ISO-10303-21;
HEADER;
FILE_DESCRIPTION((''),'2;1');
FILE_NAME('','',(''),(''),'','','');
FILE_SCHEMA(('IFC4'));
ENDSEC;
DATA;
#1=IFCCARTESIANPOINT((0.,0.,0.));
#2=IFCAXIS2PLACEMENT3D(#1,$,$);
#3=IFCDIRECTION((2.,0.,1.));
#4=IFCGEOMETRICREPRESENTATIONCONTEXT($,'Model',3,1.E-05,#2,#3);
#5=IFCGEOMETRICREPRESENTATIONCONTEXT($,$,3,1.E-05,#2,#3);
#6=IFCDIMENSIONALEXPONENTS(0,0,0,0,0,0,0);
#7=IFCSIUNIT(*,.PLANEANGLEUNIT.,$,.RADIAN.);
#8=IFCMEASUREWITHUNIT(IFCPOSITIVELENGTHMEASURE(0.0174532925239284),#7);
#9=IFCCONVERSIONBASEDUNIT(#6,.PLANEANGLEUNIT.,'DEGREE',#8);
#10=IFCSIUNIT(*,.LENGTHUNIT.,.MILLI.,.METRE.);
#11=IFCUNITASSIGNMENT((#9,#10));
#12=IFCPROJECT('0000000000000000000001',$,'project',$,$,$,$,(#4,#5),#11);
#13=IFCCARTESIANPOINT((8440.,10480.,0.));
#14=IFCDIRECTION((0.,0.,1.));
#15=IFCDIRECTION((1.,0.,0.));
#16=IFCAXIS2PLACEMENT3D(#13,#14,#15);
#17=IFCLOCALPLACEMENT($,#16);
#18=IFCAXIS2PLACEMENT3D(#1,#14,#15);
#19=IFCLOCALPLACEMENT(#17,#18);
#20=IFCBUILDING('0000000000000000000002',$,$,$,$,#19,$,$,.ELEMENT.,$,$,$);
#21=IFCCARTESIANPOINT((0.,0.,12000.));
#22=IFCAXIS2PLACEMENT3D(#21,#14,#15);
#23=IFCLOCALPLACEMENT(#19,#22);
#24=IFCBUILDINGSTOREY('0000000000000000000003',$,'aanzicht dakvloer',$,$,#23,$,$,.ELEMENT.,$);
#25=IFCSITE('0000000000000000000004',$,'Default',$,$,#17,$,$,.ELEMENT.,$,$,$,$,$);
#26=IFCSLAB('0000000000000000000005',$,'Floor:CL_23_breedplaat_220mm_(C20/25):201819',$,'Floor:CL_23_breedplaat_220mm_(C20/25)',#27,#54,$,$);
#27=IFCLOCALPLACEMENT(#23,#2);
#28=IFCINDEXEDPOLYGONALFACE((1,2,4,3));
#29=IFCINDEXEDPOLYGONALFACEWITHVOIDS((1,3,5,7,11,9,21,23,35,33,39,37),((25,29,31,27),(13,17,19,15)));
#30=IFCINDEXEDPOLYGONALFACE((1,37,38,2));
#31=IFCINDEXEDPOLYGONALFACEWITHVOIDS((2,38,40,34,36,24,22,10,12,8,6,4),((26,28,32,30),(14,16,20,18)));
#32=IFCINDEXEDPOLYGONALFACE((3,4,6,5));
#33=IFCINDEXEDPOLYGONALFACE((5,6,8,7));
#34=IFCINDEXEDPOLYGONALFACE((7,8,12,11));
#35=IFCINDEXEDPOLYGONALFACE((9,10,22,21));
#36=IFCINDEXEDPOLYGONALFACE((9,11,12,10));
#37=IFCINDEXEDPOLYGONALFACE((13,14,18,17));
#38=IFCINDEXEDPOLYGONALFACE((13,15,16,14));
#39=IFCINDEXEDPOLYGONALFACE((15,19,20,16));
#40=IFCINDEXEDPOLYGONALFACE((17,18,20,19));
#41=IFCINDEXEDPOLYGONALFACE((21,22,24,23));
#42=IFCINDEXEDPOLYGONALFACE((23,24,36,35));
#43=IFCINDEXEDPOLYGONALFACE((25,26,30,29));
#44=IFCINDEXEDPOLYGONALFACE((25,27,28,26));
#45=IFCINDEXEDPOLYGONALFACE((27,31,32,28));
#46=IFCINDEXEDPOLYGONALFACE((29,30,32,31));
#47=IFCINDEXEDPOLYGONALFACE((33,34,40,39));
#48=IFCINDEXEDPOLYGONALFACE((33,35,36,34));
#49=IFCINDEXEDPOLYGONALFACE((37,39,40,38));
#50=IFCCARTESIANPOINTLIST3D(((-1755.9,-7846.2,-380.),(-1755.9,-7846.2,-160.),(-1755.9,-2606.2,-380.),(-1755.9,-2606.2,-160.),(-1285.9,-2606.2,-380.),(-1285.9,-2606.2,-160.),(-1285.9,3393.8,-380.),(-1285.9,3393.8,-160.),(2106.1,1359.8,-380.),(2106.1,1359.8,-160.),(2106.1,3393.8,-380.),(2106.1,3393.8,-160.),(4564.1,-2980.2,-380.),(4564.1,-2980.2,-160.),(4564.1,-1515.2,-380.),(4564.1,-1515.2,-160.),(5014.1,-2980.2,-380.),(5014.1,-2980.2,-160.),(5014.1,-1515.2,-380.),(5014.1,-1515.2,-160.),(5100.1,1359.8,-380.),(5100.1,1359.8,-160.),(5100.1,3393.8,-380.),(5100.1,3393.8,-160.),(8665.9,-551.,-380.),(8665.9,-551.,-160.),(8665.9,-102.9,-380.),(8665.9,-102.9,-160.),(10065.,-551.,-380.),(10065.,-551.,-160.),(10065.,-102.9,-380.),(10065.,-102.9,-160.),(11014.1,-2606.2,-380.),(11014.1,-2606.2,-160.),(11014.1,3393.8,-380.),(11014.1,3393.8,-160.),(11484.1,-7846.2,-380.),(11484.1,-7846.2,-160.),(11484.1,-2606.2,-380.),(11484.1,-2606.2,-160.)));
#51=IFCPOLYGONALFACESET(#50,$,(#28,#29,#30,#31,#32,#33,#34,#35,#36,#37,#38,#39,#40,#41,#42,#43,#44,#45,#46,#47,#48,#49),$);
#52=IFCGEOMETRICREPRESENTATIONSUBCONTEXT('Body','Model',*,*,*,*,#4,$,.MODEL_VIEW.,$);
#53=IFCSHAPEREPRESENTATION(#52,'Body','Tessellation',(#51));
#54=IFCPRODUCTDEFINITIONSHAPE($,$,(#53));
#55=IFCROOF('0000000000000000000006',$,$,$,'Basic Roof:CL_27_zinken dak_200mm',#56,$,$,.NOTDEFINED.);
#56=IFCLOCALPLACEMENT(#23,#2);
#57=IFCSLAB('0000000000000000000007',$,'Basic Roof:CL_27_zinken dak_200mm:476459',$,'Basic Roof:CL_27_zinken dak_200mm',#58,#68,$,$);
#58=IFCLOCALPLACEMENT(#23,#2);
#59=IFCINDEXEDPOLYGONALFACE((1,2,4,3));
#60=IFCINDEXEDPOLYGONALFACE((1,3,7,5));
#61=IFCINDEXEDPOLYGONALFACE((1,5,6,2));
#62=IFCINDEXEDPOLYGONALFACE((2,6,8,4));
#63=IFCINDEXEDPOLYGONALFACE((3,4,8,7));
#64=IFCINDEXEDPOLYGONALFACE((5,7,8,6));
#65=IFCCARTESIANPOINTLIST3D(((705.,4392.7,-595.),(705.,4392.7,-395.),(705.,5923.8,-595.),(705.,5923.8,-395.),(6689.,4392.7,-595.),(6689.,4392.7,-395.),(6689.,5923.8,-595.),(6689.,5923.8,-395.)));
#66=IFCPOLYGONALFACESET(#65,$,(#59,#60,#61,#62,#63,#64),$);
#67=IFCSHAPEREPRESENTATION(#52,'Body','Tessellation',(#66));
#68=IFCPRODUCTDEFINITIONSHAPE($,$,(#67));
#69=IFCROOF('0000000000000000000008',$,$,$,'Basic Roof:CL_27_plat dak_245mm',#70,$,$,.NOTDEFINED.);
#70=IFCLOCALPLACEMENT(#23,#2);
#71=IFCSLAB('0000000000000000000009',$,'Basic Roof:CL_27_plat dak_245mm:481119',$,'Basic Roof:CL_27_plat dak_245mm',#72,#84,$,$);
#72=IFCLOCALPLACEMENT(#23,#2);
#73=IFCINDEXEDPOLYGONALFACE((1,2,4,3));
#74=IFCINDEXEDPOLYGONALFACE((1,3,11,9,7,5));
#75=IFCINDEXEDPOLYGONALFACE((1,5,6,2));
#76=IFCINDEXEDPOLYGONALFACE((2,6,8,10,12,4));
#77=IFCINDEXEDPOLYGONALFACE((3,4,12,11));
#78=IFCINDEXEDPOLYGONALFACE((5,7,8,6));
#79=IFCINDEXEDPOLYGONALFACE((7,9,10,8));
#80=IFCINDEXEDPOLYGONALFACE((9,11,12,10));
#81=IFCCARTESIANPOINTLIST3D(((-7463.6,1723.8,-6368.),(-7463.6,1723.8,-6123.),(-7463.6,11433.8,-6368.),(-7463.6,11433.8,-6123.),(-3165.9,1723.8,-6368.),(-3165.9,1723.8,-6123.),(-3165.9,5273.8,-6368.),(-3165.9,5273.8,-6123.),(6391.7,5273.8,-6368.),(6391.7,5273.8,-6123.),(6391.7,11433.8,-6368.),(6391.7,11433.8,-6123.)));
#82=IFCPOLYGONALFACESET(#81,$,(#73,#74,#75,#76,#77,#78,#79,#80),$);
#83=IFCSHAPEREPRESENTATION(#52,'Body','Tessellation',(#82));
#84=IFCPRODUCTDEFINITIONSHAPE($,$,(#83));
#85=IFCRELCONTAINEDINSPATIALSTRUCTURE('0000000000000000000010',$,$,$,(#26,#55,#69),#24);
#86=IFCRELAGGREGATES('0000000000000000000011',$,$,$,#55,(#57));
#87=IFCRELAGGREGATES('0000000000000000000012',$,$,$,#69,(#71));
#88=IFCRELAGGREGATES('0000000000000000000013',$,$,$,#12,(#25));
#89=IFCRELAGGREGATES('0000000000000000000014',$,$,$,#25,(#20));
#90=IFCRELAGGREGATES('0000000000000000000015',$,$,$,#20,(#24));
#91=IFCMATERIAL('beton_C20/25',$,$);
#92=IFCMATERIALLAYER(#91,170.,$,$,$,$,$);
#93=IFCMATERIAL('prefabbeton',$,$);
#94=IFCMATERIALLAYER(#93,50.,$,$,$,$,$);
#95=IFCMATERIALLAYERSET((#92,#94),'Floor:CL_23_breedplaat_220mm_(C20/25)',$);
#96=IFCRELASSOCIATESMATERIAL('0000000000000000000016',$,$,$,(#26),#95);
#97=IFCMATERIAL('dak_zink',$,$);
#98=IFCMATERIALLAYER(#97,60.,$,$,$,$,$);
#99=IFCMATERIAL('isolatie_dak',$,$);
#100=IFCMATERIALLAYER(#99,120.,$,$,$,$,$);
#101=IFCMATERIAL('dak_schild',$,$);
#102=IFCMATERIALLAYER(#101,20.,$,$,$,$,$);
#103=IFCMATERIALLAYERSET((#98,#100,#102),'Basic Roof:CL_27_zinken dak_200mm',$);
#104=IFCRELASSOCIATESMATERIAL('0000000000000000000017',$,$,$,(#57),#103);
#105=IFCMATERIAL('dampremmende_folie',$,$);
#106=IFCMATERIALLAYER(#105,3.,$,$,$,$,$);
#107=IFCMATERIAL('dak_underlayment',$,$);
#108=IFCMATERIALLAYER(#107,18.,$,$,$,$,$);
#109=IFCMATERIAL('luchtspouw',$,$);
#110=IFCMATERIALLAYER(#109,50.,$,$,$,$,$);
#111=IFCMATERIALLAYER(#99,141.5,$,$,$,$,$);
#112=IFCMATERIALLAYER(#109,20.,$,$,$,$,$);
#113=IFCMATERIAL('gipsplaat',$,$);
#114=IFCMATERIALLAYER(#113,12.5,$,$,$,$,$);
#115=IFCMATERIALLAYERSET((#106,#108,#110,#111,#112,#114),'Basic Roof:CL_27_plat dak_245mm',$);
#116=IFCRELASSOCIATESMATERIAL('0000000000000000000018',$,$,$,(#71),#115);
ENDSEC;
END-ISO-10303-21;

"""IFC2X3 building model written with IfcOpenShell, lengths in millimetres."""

from ifc_helpers import new_model, entity, si_unit, converted_unit, direction, frame, frame_2d, origin, origin_with_axes, origin_2d_with_axis, place, context, subcontext, project, spatial, polyline, rectangle, outline, extrude, material, layer, layer_set, layer_usage, element, aggregate, save


model = new_model("IFC2X3")

# Units and contexts
model_context = context("Model", 3, precision=1e-05, world=origin(), true_north=direction((2.0, 0.0, 1.0)))
context_of_model = context(None, 3, precision=1e-05, world=origin(), true_north=direction((2.0, 0.0, 1.0)))
body_context = subcontext(model_context, "Body", "Model", "MODEL_VIEW")
ifc_project = project(units=[converted_unit("PLANEANGLEUNIT", "DEGREE", entity("IfcPositiveLengthMeasure", 0.0174532925239284), si_unit("PLANEANGLEUNIT", "RADIAN"), dimensions=[0, 0, 0, 0, 0, 0, 0]), si_unit("LENGTHUNIT", "METRE", prefix="MILLI")], contexts=[model_context, context_of_model])

# Site, building, storey
site_placement = place(None, frame((8440.0, 10480.0, 0.0), z_axis=(0.0, 0.0, 1.0), x_axis=(1.0, 0.0, 0.0)))
site = spatial("IfcSite", under=ifc_project, at=site_placement, Name="Default", CompositionType="ELEMENT")
building_placement = place(site_placement, origin_with_axes())
building = spatial("IfcBuilding", under=site, at=building_placement, CompositionType="ELEMENT")
storey_placement = place(building_placement, frame((0.0, 0.0, 12000.0), z_axis=(0.0, 0.0, 1.0), x_axis=(1.0, 0.0, 0.0)))
storey = spatial("IfcBuildingStorey", under=building, at=storey_placement, Name="aanzicht dakvloer", CompositionType="ELEMENT")

# Slab, openings
ifc_material_1 = material(Name="beton_C20/25")
ifc_layer_1 = layer(ifc_material_1, 170.0)
ifc_material_2 = material(Name="prefabbeton")
ifc_layer_2 = layer(ifc_material_2, 50.0)
ifc_layer_set_1 = layer_set([ifc_layer_1, ifc_layer_2], Name="Floor:CL_23_breedplaat_220mm_(C20/25)")
ifc_layer_usage = layer_usage(ifc_layer_set_1, "AXIS3", "POSITIVE", 0.0)
slab_1_placement = place(storey_placement, frame((-1755.9, -7846.2, -380.0), z_axis=(0.0, 0.0, 1.0), x_axis=(1.0, 0.0, 0.0)))
slab_1 = element("IfcSlab", 1, at=slab_1_placement, inside=storey, material=ifc_layer_usage, Name="Floor:CL_23_breedplaat_220mm_(C20/25):201819", ObjectType="Floor:CL_23_breedplaat_220mm_(C20/25)", context=body_context, shape_type="SweptSolid", body=[
    extrude(outline(polyline([(2758.0, 5620.0), (2758.0, 3586.0), (-236.0, 3586.0), (-236.0, 5620.0), (-6150.0, 5620.0), (-6150.0, -380.0), (-6620.0, -380.0), (-6620.0, -5620.0), (6620.0, -5620.0), (6620.0, -380.0), (6150.0, -380.0), (6150.0, 5620.0), (2758.0, 5620.0)])), frame((6620.0, 5620.0, 220.0), z_axis=(0.0, 0.0, -1.0), x_axis=(-1.0, 0.0, 0.0)), (0.0, 0.0, 1.0), 220.0),
])
opening_1_placement = place(slab_1_placement, frame((11121.4, 7519.3, 220.0), z_axis=(0.0, 0.0, 1.0), x_axis=(1.0, 0.0, 0.0)))
element("IfcOpeningElement", 2, at=opening_1_placement, cuts=slab_1, ObjectType="Opening", context=body_context, shape_type="SweptSolid", body=[
    extrude(rectangle(XDim=448.1, YDim=1399.0, at=origin_2d_with_axis()), frame((0.0, 0.0, 0.0), z_axis=(0.0, 0.0, -1.0), x_axis=(0.0, -1.0, 0.0)), (0.0, 0.0, 1.0), 220.0),
])
opening_2_placement = place(slab_1_placement, frame((6545.0, 5598.5, 220.0), z_axis=(0.0, 0.0, 1.0), x_axis=(1.0, 0.0, 0.0)))
element("IfcOpeningElement", 3, at=opening_2_placement, cuts=slab_1, ObjectType="Opening", context=body_context, shape_type="SweptSolid", body=[
    extrude(rectangle(XDim=1465.0, YDim=450.0, at=origin_2d_with_axis()), frame((0.0, 0.0, 0.0), z_axis=(0.0, 0.0, -1.0), x_axis=(0.0, -1.0, 0.0)), (0.0, 0.0, 1.0), 220.0),
])

# Roofs, slabs
roof_1_placement = place(storey_placement, frame((705.0, 4392.7, -595.0), z_axis=(0.0, 0.0, 1.0), x_axis=(1.0, 0.0, 0.0)))
roof_1 = element("IfcRoof", 4, at=roof_1_placement, inside=storey, ObjectType="Basic Roof:CL_27_zinken dak_200mm", ShapeType="NOTDEFINED")
ifc_material_3 = material(Name="dak_zink")
ifc_layer_3 = layer(ifc_material_3, 60.0)
ifc_material_4 = material(Name="isolatie_dak")
ifc_layer_4 = layer(ifc_material_4, 120.0)
ifc_material_5 = material(Name="dak_schild")
ifc_layer_5 = layer(ifc_material_5, 20.0)
ifc_layer_set_2 = layer_set([ifc_layer_3, ifc_layer_4, ifc_layer_5], Name="Basic Roof:CL_27_zinken dak_200mm")
slab_2_placement = place(roof_1_placement, origin_with_axes())
slab_2 = element("IfcSlab", 5, at=slab_2_placement, material=ifc_layer_set_2, Name="Basic Roof:CL_27_zinken dak_200mm:476459", ObjectType="Basic Roof:CL_27_zinken dak_200mm", context=body_context, shape_type="SweptSolid", body=[
    extrude(rectangle(XDim=5984.0, YDim=1531.1, at=frame_2d((0.0, 0.0), x_axis=(1.0, 0.0))), frame((2992.0, 765.5, 0.0)), (0.0, 0.0, 1.0), 200.0),
])
aggregate(roof_1, [slab_2])
roof_2_placement = place(storey_placement, frame((-7463.6, 1723.8, -6368.0), z_axis=(0.0, 0.0, 1.0), x_axis=(1.0, 0.0, 0.0)))
roof_2 = element("IfcRoof", 6, at=roof_2_placement, inside=storey, ObjectType="Basic Roof:CL_27_plat dak_245mm", ShapeType="NOTDEFINED")
ifc_material_6 = material(Name="dampremmende_folie")
ifc_layer_6 = layer(ifc_material_6, 3.0)
ifc_material_7 = material(Name="dak_underlayment")
ifc_layer_7 = layer(ifc_material_7, 18.0)
ifc_material_8 = material(Name="luchtspouw")
ifc_layer_8 = layer(ifc_material_8, 50.0)
ifc_layer_9 = layer(ifc_material_4, 141.5)
ifc_layer_10 = layer(ifc_material_8, 20.0)
ifc_material_9 = material(Name="gipsplaat")
ifc_layer_11 = layer(ifc_material_9, 12.5)
ifc_layer_set_3 = layer_set([ifc_layer_6, ifc_layer_7, ifc_layer_8, ifc_layer_9, ifc_layer_10, ifc_layer_11], Name="Basic Roof:CL_27_plat dak_245mm")
slab_3_placement = place(roof_2_placement, origin_with_axes())
slab_3 = element("IfcSlab", 7, at=slab_3_placement, material=ifc_layer_set_3, Name="Basic Roof:CL_27_plat dak_245mm:481119", ObjectType="Basic Roof:CL_27_plat dak_245mm", context=body_context, shape_type="SweptSolid", body=[
    extrude(outline(polyline([(-6927.7, 4855.0), (-6927.7, -4855.0), (-2630.0, -4855.0), (-2630.0, -1305.0), (6927.7, -1305.0), (6927.7, 4855.0), (-6927.7, 4855.0)])), frame((6927.7, 4855.0, 0.0)), (0.0, 0.0, 1.0), 245.0),
])
aggregate(roof_2, [slab_3])

save(model, "model.ifc")
